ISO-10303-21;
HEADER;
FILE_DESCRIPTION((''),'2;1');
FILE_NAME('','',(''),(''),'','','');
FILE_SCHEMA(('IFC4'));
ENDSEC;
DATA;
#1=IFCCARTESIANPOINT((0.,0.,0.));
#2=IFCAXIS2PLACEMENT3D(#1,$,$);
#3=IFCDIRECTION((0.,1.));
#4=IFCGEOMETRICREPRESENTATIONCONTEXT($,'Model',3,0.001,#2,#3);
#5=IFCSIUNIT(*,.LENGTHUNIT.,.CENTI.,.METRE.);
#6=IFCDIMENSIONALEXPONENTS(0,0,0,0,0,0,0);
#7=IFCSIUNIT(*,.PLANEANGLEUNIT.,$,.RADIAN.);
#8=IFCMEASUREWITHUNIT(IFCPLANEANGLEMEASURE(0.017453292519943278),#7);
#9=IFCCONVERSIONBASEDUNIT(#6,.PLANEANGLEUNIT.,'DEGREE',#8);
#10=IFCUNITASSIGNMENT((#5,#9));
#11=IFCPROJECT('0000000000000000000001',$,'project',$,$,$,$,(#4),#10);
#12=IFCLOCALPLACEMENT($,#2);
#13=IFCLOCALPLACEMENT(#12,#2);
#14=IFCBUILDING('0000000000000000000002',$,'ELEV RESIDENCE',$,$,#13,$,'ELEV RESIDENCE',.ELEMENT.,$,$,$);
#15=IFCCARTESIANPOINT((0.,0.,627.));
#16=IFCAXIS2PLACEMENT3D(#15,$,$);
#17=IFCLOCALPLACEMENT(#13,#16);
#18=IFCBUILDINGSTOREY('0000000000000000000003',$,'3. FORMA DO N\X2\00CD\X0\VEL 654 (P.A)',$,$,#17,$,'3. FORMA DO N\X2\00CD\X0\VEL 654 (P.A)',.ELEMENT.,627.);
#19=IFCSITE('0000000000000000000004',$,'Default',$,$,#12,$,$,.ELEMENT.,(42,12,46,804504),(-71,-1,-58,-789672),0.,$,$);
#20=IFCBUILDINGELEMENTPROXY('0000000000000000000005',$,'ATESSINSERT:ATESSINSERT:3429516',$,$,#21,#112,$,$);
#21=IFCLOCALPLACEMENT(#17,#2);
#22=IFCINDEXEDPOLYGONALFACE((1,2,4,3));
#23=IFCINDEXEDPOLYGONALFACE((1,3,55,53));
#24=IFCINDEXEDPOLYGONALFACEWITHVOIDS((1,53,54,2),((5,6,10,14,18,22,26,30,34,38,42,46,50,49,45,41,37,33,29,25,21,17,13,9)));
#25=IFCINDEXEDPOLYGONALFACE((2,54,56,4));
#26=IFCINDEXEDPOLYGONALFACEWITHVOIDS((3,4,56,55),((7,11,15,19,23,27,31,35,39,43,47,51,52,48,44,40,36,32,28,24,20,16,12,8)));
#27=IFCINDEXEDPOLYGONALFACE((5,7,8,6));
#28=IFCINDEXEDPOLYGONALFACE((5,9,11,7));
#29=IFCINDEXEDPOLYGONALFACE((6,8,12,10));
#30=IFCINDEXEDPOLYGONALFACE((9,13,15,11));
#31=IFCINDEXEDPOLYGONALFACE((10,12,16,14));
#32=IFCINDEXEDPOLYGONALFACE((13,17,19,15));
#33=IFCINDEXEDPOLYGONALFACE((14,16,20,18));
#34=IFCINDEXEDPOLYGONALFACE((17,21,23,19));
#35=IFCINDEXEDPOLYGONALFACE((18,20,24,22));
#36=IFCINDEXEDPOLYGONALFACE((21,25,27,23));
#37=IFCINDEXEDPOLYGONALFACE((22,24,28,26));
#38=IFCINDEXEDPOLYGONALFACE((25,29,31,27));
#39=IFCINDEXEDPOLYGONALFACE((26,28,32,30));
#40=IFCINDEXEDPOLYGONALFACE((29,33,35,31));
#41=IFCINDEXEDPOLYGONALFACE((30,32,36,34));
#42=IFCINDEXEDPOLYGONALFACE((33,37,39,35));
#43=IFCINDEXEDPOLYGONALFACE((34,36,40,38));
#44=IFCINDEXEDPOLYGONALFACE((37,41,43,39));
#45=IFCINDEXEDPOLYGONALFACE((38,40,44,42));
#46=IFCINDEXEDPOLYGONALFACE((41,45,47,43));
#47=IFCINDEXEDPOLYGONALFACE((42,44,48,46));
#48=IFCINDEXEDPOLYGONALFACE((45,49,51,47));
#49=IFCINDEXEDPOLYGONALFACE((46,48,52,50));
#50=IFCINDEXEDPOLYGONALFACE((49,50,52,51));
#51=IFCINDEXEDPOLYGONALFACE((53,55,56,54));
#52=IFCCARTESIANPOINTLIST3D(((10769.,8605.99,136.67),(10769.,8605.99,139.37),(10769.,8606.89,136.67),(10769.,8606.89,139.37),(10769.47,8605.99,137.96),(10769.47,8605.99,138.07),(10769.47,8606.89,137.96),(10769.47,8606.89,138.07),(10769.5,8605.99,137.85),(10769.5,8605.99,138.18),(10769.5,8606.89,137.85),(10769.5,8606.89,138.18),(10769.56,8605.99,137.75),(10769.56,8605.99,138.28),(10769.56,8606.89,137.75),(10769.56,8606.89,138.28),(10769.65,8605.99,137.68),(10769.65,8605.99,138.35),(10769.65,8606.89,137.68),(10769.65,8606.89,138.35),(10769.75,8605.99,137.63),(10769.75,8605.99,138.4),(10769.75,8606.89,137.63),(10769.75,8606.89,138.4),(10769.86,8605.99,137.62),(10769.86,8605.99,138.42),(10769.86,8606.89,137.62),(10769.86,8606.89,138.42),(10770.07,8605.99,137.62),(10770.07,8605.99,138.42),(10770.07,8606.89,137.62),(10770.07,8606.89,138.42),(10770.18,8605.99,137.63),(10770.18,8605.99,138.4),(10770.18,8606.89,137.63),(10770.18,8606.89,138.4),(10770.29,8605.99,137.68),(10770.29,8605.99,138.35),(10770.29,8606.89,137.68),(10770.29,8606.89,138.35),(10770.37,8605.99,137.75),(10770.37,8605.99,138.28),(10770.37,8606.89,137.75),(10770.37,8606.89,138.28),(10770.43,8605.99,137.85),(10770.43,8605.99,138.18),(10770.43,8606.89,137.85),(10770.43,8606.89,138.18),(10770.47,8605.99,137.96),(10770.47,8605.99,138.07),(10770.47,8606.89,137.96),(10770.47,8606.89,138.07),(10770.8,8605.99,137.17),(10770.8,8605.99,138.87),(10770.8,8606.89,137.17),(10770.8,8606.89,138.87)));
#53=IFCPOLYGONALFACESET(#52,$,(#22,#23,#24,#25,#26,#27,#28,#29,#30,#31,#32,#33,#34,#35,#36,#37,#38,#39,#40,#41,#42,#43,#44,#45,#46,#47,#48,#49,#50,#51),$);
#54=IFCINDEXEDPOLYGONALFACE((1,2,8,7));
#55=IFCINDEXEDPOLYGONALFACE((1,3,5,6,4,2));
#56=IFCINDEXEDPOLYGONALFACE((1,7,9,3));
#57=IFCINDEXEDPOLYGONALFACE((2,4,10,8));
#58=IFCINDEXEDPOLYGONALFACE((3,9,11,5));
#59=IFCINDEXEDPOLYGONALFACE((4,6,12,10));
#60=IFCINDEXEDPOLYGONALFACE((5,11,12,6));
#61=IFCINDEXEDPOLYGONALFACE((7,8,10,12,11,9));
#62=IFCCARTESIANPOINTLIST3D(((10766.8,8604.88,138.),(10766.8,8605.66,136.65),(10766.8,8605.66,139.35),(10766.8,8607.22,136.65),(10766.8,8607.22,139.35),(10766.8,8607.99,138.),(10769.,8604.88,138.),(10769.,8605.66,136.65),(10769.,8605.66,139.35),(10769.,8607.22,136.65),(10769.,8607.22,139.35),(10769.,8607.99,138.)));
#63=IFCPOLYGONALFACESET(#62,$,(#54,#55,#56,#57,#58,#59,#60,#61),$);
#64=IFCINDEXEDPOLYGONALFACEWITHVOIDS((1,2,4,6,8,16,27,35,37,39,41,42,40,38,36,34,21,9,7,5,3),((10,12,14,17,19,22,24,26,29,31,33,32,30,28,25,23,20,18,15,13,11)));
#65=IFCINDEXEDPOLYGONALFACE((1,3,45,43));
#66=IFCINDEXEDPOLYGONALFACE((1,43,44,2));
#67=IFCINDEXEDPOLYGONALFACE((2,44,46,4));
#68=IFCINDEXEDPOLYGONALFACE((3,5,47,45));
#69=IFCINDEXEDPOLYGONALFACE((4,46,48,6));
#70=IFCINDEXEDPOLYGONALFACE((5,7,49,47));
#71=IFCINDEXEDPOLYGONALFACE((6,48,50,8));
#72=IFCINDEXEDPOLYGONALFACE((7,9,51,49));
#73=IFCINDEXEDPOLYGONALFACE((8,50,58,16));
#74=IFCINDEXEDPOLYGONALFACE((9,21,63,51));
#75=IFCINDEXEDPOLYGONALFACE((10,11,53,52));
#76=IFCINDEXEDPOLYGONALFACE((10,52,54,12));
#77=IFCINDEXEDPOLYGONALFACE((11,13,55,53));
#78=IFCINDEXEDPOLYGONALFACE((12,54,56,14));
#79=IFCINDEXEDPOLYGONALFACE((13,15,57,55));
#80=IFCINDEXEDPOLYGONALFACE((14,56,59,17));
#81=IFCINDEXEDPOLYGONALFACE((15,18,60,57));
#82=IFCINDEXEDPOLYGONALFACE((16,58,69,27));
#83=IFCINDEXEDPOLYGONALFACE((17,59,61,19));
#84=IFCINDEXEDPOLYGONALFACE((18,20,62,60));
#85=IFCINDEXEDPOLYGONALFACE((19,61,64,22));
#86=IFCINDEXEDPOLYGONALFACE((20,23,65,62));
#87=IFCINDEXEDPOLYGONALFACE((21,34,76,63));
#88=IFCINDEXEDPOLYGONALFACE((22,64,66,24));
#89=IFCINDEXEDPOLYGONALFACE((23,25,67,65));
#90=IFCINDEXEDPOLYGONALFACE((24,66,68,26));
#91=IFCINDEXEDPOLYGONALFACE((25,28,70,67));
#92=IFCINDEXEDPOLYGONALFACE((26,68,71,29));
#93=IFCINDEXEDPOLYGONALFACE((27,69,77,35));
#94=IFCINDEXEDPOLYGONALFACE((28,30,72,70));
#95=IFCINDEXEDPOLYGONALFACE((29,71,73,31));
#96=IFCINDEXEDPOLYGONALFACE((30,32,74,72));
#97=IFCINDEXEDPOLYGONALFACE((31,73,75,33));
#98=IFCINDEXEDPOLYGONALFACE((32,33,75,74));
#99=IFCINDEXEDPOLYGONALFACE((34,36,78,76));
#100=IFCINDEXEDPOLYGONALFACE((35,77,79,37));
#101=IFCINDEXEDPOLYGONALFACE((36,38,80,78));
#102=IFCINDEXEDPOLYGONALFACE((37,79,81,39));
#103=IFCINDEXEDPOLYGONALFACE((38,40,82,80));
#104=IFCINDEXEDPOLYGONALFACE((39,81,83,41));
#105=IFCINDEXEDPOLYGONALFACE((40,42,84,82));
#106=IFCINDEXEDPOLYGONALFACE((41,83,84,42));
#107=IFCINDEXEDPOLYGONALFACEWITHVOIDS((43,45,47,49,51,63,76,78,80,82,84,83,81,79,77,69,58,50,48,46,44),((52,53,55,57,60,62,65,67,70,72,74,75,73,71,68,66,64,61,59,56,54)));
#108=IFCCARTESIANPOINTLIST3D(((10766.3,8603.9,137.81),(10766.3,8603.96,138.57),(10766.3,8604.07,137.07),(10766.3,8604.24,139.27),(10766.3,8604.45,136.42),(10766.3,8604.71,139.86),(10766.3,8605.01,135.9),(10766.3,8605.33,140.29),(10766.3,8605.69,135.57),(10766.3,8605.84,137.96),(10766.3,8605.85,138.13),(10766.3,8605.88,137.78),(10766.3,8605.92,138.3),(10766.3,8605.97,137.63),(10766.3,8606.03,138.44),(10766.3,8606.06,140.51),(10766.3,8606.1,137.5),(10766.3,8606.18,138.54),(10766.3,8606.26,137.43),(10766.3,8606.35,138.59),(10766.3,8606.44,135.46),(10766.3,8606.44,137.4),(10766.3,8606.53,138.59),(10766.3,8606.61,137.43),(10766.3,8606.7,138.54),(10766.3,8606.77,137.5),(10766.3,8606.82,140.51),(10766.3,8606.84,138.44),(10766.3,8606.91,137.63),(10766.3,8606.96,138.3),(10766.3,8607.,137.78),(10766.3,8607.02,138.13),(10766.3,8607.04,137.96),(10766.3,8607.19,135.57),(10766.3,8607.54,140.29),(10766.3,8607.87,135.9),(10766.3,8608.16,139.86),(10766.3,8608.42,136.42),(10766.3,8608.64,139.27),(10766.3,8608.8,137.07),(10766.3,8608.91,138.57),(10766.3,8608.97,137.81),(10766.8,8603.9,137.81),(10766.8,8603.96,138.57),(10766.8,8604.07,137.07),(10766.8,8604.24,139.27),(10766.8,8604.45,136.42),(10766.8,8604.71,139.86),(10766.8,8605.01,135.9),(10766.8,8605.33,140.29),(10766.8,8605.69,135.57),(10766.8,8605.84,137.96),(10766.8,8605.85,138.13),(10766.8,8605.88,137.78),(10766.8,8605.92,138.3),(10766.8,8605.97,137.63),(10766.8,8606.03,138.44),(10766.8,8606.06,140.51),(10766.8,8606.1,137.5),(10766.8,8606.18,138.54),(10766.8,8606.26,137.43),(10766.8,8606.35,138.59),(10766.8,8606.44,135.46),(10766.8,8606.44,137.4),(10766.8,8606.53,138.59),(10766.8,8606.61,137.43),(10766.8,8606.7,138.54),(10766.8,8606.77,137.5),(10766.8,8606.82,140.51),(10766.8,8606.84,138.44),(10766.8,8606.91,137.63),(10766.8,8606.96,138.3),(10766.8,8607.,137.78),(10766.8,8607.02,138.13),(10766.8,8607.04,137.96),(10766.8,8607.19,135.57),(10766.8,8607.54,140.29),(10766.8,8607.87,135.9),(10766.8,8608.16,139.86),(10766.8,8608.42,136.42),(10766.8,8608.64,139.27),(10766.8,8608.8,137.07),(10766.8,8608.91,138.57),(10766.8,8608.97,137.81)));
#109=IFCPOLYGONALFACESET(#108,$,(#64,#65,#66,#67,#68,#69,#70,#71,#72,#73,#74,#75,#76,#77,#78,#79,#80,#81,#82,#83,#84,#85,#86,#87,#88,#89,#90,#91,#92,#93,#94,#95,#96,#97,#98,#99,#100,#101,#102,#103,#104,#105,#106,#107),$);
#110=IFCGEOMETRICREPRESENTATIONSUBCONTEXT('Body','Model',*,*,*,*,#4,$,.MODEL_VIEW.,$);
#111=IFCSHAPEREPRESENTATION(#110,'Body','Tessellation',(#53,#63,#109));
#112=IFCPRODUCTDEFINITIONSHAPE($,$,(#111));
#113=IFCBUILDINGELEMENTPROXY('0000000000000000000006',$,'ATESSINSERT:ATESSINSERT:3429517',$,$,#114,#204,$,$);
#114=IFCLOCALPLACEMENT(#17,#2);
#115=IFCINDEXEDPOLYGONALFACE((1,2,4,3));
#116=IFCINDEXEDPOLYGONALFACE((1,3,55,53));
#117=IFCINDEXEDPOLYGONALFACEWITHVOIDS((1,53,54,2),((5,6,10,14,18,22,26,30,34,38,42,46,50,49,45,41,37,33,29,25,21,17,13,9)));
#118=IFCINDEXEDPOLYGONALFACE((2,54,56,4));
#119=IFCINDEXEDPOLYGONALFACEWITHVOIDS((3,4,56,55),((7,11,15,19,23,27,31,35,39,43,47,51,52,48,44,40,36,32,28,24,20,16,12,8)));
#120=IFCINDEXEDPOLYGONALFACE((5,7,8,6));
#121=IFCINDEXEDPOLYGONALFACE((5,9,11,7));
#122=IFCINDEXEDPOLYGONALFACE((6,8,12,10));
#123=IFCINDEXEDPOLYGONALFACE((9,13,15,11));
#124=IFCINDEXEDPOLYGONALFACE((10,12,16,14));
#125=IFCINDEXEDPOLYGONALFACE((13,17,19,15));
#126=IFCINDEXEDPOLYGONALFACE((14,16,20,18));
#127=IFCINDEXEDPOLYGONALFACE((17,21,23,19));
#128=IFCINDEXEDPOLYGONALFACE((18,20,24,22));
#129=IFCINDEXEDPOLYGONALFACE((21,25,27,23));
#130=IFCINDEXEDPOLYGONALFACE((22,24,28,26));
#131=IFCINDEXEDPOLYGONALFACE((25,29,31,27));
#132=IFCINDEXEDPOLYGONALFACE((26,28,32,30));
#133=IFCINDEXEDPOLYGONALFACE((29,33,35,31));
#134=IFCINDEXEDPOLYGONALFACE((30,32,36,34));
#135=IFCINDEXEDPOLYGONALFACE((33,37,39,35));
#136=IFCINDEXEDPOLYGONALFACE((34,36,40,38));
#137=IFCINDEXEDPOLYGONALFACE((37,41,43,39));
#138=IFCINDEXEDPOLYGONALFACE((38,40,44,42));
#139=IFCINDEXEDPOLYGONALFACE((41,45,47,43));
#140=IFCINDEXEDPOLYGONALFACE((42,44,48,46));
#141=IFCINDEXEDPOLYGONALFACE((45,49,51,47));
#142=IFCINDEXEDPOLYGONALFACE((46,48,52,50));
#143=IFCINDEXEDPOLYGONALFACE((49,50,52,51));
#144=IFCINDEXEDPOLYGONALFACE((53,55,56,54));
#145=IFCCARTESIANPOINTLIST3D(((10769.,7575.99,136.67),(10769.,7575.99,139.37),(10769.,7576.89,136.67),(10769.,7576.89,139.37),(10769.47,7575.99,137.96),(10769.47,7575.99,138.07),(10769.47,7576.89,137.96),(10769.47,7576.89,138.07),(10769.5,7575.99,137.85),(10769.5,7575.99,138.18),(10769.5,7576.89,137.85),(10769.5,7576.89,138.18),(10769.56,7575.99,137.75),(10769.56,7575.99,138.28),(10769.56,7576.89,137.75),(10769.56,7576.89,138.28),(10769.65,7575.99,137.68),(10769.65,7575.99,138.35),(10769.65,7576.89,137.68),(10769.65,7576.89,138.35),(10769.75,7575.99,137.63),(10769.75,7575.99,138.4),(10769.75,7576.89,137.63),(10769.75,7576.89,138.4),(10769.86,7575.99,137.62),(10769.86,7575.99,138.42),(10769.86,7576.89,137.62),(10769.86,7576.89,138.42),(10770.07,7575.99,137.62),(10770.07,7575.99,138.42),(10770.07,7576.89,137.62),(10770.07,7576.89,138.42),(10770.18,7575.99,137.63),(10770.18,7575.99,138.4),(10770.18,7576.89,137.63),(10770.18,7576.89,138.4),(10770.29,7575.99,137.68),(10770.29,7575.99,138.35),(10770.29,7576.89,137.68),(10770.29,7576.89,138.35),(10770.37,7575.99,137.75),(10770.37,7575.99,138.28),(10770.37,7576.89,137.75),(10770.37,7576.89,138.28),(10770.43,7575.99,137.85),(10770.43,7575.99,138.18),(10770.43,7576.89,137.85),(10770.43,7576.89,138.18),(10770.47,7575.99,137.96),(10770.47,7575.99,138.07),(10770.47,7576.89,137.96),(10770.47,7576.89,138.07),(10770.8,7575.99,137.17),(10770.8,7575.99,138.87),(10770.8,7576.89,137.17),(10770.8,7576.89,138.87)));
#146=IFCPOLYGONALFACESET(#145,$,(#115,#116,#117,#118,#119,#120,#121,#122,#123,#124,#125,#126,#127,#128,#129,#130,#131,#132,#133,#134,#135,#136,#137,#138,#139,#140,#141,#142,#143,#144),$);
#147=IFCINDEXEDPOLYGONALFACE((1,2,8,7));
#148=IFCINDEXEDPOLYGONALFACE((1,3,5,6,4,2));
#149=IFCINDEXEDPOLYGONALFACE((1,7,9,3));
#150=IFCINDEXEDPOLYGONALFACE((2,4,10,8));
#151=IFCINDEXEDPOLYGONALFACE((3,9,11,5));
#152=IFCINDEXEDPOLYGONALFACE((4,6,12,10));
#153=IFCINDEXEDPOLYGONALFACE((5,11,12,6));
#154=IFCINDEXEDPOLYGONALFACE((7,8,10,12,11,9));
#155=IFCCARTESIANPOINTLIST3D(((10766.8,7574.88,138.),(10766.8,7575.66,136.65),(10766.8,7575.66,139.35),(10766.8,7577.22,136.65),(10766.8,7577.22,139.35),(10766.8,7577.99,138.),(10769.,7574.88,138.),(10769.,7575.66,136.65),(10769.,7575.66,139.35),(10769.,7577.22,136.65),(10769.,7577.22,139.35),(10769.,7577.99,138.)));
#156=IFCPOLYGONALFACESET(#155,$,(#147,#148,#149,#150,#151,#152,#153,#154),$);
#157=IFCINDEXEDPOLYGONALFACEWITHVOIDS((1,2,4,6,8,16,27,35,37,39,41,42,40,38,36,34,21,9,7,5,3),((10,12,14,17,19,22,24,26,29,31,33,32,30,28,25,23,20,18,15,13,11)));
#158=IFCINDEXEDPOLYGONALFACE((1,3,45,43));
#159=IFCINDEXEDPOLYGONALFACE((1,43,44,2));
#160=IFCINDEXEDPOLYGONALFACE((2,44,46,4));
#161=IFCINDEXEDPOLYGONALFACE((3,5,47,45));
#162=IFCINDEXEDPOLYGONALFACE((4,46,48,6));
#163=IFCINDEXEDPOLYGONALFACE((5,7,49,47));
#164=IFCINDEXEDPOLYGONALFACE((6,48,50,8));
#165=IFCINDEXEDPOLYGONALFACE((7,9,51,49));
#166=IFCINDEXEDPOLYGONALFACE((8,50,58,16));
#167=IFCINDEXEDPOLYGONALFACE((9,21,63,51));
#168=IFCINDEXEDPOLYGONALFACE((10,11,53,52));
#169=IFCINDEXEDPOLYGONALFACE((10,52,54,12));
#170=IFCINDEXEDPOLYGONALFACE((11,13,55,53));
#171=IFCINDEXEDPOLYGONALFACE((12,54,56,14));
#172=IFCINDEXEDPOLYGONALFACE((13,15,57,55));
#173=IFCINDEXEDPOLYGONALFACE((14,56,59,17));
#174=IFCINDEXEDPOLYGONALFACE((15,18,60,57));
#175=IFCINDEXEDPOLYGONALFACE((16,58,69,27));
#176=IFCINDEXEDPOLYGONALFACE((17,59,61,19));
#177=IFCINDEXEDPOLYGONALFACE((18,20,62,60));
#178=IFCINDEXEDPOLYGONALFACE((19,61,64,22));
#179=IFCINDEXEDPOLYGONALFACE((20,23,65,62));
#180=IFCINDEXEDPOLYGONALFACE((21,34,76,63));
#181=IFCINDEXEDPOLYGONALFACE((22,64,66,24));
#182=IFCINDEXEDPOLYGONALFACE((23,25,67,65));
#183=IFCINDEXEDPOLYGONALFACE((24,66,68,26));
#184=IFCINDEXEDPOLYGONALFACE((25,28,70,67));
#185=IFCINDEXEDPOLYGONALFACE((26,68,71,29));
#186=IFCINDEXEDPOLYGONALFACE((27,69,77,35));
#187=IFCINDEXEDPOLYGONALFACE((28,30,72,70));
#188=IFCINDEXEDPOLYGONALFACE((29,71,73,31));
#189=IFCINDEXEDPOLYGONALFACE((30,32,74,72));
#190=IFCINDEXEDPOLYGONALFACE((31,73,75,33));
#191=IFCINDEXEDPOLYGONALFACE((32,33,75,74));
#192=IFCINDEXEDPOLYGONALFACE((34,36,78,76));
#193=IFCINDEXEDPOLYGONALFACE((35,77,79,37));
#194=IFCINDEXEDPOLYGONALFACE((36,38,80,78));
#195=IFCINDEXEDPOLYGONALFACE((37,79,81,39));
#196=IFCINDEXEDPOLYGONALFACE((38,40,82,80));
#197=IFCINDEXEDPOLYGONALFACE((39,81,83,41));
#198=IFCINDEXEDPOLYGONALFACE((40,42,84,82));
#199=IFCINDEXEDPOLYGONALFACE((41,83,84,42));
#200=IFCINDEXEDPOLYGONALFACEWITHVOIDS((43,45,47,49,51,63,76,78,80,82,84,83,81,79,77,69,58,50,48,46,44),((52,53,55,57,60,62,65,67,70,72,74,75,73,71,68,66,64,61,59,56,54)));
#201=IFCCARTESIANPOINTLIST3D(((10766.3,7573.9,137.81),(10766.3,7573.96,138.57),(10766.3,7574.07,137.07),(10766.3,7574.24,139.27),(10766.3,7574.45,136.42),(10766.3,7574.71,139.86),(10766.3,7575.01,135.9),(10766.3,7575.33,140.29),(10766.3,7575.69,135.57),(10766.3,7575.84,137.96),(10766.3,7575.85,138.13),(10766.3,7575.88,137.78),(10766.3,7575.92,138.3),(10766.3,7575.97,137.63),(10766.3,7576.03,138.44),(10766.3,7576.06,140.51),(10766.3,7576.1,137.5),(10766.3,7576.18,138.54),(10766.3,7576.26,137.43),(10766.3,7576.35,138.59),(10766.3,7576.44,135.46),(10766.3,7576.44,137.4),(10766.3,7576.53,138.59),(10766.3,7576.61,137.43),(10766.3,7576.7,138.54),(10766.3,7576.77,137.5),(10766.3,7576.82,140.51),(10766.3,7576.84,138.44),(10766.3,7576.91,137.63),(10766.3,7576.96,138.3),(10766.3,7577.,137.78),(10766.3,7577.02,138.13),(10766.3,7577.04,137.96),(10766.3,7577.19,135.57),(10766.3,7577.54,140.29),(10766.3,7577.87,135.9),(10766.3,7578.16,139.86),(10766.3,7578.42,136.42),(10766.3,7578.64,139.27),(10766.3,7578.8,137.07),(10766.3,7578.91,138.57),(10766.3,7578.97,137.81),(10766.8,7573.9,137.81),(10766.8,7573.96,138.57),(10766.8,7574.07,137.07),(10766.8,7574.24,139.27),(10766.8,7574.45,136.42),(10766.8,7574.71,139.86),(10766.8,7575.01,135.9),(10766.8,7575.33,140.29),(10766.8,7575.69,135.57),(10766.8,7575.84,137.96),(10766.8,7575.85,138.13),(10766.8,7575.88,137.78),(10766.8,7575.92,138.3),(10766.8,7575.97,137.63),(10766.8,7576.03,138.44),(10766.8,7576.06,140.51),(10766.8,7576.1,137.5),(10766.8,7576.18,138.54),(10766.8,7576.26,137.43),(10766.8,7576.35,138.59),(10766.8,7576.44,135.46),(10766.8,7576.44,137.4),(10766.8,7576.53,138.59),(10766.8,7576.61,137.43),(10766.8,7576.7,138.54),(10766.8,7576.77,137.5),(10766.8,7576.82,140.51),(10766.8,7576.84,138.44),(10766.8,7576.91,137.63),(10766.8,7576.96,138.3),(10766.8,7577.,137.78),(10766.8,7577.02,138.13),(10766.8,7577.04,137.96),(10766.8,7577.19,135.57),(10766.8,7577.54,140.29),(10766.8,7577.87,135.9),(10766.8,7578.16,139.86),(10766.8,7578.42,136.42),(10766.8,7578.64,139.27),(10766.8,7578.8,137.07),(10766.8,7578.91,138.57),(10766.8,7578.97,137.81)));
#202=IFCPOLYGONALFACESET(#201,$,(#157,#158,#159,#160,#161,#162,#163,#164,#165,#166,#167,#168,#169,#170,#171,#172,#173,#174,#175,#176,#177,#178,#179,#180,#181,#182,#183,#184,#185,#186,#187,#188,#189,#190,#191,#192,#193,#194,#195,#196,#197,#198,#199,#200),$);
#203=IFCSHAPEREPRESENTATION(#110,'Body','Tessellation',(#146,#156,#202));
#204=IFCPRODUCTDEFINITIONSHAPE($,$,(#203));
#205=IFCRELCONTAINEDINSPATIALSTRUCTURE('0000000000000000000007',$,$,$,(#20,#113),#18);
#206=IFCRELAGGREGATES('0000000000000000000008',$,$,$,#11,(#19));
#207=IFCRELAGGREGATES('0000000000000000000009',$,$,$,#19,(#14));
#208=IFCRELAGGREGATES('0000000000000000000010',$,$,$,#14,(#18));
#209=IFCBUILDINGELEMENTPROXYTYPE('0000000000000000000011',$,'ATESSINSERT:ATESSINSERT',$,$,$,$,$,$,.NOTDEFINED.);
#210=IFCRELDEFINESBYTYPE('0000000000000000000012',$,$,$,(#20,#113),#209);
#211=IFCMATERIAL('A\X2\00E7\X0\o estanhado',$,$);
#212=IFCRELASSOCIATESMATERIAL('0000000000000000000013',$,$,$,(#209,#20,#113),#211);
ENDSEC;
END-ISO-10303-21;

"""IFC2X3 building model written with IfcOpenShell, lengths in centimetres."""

from ifc_helpers import new_model, entity, si_unit, converted_unit, direction, frame, frame_2d, origin, place, context, subcontext, project, spatial, polyline, circle_curve, parameter, trimmed, segment, composite_curve, hollow_circle, outline, extrude, source, transform, mapped, material, type_object, type_shapes, element, save


model = new_model("IFC2X3")

# Units and contexts
model_context = context("Model", 3, precision=0.001, world=origin(), true_north=direction((0.0, 1.0)))
body_context = subcontext(model_context, "Body", "Model", "MODEL_VIEW")
ifc_project = project(units=[si_unit("LENGTHUNIT", "METRE", prefix="CENTI"), converted_unit("PLANEANGLEUNIT", "DEGREE", entity("IfcPlaneAngleMeasure", 0.017453292519943278), si_unit("PLANEANGLEUNIT", "RADIAN"), dimensions=[0, 0, 0, 0, 0, 0, 0])], contexts=[model_context])

# Site, building, storey
site_placement = place(None, origin())
site = spatial("IfcSite", under=ifc_project, at=site_placement, Name="Default", CompositionType="ELEMENT", RefLatitude=(42, 12, 46, 804504), RefLongitude=(-71, -1, -58, -789672), RefElevation=0.0)
building_placement = place(site_placement, origin())
building = spatial("IfcBuilding", under=site, at=building_placement, Name="ELEV RESIDENCE", LongName="ELEV RESIDENCE", CompositionType="ELEMENT")
storey_placement = place(building_placement, frame((0.0, 0.0, 627.0)))
storey = spatial("IfcBuildingStorey", under=building, at=storey_placement, Name="3. FORMA DO NÍVEL 654 (P.A)", LongName="3. FORMA DO NÍVEL 654 (P.A)", CompositionType="ELEMENT", Elevation=627.0)

# Building element proxies
ifc_material_1 = material(Name="Aço estanhado")
building_element_proxy_type_1 = type_object("IfcBuildingElementProxyType", Name="ATESSINSERT:ATESSINSERT", PredefinedType="NOTDEFINED", material=ifc_material_1)
shared_shape_1 = source(origin(), body_context, "Body", "SweptSolid", [
    extrude(outline(polyline([(-1.35, -0.9), (1.35, -0.9), (0.85, 0.9), (-0.85, 0.9), (-1.35, -0.9)]), holes=[composite_curve([segment(trimmed(circle_curve(frame_2d((0.0, 0.17), x_axis=(1.0, 0.0)), 0.4), [parameter(0.0)], [parameter(180.0)], True, "PARAMETER"), False, "CONTINUOUS"), segment(polyline([(0.4, 0.17), (0.4, -0.03)]), True, "CONTINUOUS"), segment(trimmed(circle_curve(frame_2d((0.0, -0.03), x_axis=(1.0, 0.0)), 0.4), [parameter(180.0)], [parameter(0.0)], True, "PARAMETER"), False, "CONTINUOUS"), segment(polyline([(-0.4, -0.03), (-0.4, 0.17)]), True, "CONTINUOUS")], self_intersect=False)]), frame((-1.4, -0.45, 30.02), z_axis=(0.0, 1.0, 0.0), x_axis=(0.0, 0.0, 1.0)), (0.0, 0.0, 1.0), 0.9),
    extrude(outline(polyline([(-0.78, -1.35), (0.78, -1.35), (1.56, 0.0), (0.78, 1.35), (-0.78, 1.35), (-1.56, 0.0), (-0.78, -1.35)])), frame((-4.5, 0.0, 30.0), z_axis=(1.0, 0.0, 0.0), x_axis=(0.0, 1.0, 0.0)), (0.0, 0.0, 1.0), 2.2),
    extrude(hollow_circle(Radius=2.54, WallThickness=1.94, at=frame_2d((0.0, 0.0), x_axis=(1.0, 0.0))), frame((-5.0, 0.0, 30.0), z_axis=(1.0, 0.0, 0.0), x_axis=(0.0, 0.0, -1.0)), (0.0, 0.0, 1.0), 0.5),
])
type_shapes(building_element_proxy_type_1, [shared_shape_1])
for number, where, name in (
    (1, (10771.3, 8606.44, 108.0), "ATESSINSERT:ATESSINSERT:3429516"),
    (2, (10771.3, 7576.44, 108.0), "ATESSINSERT:ATESSINSERT:3429517"),
):
    element("IfcBuildingElementProxy", number, at=place(storey_placement, frame(where)), inside=storey, type_object=building_element_proxy_type_1, material=ifc_material_1, Name=name, context=body_context, shape_type="MappedRepresentation", body=[
        mapped(shared_shape_1, transform((0.0, 0.0, 0.0), scale=1.0)),
    ])

save(model, "model.ifc")
